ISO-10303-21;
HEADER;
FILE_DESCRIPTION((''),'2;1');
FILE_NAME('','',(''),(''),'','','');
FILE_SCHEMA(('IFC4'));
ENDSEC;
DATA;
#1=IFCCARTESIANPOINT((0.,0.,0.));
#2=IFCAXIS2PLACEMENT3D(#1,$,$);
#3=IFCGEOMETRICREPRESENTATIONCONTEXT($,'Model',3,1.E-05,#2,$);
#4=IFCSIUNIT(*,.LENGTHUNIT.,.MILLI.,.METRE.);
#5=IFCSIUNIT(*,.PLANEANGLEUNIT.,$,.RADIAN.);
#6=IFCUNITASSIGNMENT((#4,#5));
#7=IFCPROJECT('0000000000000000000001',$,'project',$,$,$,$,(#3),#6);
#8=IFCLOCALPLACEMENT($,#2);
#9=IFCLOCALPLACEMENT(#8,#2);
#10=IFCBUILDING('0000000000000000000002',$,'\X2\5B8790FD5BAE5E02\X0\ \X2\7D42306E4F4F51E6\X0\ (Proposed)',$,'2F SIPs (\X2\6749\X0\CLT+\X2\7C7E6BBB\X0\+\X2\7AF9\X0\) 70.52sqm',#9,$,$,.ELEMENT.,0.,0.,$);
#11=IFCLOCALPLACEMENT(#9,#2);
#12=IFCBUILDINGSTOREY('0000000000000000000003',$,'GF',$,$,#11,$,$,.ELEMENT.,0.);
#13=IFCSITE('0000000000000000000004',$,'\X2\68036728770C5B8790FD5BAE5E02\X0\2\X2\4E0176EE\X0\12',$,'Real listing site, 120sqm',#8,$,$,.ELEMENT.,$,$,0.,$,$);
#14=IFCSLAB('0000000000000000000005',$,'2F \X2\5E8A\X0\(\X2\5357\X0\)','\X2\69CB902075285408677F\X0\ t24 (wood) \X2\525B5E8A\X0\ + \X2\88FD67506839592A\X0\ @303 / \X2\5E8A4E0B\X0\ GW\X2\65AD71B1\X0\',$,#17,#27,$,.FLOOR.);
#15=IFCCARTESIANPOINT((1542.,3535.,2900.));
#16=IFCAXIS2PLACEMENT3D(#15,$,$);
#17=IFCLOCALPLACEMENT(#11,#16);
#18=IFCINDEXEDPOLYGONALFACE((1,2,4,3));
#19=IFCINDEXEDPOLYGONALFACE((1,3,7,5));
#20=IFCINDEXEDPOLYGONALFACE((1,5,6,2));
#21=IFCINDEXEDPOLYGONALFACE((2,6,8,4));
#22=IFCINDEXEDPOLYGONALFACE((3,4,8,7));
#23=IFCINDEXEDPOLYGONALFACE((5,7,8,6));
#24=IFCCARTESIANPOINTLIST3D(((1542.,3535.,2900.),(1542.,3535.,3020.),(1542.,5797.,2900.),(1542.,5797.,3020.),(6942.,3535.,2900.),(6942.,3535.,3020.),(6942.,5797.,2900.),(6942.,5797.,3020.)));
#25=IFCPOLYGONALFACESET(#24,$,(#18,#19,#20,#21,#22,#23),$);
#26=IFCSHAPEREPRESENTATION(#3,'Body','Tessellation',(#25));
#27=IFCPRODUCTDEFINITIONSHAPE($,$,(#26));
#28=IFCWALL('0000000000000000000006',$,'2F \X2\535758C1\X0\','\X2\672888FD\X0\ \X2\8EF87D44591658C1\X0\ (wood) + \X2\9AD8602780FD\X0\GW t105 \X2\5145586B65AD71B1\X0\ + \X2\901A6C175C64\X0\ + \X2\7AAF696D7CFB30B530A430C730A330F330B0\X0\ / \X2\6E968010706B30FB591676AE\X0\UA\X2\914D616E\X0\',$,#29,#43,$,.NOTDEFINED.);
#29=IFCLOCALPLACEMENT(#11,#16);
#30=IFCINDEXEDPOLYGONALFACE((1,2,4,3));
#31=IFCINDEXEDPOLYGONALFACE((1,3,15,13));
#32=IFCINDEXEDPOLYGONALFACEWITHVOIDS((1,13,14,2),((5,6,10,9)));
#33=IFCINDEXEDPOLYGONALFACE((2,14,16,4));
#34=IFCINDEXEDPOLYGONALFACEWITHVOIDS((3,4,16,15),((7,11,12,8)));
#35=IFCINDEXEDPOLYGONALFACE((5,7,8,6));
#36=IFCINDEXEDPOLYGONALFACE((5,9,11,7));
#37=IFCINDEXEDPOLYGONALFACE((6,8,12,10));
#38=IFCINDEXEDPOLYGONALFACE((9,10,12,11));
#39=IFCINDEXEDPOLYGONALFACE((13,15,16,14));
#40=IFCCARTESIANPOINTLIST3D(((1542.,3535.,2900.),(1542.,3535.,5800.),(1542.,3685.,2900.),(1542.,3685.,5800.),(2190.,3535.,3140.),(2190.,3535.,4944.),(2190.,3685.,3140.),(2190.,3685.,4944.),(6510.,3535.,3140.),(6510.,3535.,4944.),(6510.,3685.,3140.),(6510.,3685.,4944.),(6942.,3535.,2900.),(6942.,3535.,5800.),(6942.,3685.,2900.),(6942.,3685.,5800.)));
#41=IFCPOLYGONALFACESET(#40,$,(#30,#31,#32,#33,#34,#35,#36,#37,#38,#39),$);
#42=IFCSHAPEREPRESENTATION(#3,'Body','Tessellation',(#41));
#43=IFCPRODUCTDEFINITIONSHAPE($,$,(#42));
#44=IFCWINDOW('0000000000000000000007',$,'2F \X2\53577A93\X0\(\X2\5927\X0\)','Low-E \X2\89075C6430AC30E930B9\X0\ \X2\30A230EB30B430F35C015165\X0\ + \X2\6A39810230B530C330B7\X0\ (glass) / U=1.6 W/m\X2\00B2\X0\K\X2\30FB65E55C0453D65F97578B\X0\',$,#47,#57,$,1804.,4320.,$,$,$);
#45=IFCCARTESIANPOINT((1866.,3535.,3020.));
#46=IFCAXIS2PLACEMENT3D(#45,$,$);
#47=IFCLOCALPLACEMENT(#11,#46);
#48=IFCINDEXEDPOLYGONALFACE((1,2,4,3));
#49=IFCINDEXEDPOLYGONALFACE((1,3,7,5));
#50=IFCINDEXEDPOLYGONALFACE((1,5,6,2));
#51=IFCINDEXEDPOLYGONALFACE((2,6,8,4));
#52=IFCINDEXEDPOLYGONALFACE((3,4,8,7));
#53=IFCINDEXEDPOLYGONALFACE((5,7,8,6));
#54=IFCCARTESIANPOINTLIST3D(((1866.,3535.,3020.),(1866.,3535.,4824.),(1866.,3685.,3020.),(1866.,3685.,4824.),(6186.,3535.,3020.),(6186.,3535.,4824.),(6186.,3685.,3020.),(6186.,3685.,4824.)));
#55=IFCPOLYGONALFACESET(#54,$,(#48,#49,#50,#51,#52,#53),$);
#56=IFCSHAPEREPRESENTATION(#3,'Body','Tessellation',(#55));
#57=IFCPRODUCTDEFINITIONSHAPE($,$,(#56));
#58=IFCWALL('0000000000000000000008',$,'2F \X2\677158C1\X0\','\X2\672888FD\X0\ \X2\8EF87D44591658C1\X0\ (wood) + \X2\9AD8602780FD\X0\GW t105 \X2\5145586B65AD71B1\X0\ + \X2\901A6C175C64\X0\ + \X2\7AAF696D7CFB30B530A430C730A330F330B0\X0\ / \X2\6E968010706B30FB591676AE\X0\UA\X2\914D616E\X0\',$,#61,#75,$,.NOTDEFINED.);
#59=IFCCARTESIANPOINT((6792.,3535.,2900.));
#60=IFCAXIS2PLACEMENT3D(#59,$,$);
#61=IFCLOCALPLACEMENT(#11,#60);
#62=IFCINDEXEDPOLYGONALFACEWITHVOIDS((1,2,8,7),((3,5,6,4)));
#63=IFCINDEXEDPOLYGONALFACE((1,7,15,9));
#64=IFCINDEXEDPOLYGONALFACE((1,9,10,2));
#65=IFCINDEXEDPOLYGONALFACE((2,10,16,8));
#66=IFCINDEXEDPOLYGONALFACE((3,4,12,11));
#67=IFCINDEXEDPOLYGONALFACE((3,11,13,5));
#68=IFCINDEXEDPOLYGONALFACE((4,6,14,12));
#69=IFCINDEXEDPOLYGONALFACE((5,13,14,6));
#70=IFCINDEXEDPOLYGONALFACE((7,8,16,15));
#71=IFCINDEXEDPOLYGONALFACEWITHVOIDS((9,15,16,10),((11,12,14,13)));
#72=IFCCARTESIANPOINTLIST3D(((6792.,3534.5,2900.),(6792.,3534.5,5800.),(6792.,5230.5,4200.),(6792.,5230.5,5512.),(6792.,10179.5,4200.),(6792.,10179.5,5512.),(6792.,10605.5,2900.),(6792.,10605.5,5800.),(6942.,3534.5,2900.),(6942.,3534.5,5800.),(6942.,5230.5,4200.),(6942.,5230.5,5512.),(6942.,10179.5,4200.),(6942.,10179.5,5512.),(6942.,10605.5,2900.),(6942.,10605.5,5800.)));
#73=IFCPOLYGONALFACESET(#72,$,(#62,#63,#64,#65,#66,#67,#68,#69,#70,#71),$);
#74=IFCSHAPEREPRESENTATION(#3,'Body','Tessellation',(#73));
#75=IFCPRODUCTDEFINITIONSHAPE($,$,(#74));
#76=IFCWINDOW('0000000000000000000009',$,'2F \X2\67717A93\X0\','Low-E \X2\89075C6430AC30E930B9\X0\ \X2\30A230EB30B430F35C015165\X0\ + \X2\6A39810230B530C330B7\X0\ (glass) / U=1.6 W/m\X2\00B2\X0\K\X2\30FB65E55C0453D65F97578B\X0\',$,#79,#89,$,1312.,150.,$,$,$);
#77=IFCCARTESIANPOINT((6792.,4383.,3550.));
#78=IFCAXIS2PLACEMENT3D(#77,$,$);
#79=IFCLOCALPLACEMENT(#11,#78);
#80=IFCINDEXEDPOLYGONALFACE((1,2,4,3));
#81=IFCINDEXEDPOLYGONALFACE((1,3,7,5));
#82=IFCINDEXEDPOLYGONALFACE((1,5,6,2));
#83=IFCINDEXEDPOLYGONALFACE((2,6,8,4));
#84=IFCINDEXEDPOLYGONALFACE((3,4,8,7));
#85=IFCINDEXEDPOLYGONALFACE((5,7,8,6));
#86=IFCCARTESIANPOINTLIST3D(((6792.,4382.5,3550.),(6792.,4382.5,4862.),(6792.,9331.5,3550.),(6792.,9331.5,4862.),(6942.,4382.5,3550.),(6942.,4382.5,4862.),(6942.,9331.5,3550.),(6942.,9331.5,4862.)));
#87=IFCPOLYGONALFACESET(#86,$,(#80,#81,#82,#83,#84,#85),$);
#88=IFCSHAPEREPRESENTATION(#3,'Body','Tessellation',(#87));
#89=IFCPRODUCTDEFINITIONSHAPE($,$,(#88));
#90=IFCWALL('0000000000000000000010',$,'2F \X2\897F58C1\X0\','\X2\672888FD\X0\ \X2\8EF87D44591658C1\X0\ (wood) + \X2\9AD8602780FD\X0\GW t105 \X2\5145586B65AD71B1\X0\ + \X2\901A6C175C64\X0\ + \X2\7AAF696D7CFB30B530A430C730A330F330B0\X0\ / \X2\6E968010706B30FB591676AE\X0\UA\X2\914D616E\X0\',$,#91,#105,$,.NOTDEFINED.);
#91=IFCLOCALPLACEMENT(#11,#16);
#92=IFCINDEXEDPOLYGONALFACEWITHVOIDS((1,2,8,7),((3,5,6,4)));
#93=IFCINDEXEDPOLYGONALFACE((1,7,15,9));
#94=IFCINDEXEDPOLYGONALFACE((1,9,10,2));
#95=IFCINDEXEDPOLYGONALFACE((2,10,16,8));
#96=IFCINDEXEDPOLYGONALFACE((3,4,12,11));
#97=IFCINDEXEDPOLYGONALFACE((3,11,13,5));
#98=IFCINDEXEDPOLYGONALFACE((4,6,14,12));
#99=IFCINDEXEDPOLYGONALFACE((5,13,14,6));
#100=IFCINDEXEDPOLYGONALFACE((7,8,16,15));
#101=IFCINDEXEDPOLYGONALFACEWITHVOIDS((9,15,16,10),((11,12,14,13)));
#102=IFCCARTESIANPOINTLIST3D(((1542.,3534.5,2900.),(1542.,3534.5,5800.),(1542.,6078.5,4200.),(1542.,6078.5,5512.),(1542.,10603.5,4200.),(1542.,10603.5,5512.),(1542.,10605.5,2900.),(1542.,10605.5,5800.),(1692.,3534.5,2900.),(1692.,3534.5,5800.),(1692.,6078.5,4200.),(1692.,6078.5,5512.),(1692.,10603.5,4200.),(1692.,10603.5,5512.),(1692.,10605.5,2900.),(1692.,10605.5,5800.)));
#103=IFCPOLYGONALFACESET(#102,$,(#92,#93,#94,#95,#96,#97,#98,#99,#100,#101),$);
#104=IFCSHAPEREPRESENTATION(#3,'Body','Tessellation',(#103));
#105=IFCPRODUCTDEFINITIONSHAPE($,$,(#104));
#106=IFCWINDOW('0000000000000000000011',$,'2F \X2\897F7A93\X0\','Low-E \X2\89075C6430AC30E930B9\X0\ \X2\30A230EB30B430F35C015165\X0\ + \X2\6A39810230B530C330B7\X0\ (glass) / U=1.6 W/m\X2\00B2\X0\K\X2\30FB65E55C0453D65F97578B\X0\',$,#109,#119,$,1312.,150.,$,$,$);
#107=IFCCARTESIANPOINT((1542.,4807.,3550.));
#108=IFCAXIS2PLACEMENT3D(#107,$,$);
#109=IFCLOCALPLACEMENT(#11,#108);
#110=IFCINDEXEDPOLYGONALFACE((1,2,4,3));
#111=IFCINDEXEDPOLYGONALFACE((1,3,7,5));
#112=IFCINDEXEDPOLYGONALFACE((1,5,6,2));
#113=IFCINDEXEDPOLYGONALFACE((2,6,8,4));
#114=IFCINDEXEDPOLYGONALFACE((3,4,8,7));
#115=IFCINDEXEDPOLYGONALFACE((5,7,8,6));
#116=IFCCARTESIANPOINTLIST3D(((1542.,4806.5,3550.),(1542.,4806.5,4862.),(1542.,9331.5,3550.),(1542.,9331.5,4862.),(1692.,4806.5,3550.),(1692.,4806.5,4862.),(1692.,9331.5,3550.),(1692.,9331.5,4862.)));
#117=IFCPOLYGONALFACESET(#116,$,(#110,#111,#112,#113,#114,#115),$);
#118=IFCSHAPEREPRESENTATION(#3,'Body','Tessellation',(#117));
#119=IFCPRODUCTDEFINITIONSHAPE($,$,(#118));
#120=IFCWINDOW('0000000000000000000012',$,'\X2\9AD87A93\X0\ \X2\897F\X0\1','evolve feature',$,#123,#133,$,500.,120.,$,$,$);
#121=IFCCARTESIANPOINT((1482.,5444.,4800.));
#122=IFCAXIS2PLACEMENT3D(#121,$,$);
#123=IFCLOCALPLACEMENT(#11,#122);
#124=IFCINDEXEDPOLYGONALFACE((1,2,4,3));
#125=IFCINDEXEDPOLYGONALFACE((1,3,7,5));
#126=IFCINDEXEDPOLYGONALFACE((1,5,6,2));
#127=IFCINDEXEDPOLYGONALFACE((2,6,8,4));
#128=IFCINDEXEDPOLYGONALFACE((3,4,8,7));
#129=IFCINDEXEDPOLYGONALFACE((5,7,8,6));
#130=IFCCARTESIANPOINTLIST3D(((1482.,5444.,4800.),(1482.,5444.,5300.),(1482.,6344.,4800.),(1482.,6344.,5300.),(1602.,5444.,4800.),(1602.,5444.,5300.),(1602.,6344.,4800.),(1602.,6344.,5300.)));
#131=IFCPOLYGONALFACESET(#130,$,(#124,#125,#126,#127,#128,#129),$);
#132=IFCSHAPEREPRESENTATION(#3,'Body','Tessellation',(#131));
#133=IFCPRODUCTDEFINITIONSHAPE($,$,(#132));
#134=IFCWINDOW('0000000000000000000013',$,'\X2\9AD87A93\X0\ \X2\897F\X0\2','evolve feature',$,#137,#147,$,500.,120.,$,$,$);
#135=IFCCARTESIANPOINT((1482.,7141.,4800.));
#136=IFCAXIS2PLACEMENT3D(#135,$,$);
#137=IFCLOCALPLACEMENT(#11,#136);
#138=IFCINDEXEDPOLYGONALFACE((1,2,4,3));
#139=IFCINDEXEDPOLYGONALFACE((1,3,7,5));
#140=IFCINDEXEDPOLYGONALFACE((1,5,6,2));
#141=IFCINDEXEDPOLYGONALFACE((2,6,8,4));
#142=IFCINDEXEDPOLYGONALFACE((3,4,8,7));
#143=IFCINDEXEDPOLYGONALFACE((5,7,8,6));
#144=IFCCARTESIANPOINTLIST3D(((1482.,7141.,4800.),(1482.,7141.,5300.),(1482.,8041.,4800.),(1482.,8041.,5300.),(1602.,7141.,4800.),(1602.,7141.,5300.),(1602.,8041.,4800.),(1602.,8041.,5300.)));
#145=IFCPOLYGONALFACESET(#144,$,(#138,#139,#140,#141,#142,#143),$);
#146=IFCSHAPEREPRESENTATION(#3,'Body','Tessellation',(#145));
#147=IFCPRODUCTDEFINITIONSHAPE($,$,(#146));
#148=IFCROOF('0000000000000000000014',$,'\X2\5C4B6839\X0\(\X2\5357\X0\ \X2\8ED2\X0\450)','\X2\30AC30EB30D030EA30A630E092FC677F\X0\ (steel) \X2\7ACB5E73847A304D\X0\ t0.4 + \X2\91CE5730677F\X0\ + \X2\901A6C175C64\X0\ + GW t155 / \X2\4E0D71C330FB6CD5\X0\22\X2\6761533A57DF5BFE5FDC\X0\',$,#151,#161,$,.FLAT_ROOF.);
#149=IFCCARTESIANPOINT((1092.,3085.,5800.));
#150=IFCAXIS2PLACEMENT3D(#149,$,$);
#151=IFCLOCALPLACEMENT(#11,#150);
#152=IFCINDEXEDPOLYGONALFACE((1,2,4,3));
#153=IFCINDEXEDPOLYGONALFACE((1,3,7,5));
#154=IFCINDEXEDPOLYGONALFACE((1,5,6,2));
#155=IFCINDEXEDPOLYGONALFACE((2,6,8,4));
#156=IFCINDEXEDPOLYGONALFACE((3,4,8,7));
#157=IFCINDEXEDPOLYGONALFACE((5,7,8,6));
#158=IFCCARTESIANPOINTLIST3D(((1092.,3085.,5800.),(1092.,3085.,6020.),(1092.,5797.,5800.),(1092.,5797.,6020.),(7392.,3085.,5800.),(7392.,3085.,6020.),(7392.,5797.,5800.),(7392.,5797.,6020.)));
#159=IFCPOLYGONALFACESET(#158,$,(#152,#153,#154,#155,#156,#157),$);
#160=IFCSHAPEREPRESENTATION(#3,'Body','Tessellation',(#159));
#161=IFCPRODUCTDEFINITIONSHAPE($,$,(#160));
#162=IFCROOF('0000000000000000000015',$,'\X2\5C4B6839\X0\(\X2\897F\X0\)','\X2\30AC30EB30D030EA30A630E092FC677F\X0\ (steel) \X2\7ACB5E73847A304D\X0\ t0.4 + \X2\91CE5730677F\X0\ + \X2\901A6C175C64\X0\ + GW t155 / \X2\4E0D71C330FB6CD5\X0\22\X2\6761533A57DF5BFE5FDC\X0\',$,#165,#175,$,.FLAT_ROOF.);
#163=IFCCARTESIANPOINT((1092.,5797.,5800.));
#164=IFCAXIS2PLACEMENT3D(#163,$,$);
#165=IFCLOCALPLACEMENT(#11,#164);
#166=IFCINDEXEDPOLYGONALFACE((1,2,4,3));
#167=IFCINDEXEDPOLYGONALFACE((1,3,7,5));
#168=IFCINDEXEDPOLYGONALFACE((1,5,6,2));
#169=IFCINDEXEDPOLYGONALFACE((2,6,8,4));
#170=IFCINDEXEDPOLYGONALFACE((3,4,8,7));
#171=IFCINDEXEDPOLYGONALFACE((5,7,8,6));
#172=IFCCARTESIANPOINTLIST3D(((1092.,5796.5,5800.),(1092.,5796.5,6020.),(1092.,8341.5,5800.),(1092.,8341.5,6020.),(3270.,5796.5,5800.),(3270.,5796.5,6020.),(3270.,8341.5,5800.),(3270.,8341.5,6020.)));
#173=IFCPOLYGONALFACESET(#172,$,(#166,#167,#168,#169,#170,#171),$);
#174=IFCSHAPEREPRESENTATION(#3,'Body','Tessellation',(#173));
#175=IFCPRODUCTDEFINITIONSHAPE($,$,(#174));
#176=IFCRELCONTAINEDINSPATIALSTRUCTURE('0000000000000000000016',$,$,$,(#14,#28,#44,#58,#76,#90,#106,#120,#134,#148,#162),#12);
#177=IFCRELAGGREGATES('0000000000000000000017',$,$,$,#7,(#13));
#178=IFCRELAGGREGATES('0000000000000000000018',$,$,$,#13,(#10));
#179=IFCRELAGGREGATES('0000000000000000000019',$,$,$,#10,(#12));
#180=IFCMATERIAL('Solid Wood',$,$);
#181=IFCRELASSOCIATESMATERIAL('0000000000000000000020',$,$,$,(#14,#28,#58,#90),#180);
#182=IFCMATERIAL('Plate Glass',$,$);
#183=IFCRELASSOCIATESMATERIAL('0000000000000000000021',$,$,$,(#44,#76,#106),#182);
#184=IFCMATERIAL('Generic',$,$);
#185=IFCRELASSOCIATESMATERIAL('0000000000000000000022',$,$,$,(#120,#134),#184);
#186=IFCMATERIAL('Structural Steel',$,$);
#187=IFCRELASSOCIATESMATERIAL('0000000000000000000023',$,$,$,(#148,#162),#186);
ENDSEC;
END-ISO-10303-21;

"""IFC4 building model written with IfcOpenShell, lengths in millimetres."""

from ifc_helpers import new_model, si_unit, frame, frame_2d, origin, place, context, project, spatial, rectangle, extrude, material, element, fill, save


model = new_model("IFC4")

# Units and contexts
model_context = context("Model", 3, precision=1e-05, world=origin())
ifc_project = project(units=[si_unit("LENGTHUNIT", "METRE", prefix="MILLI"), si_unit("PLANEANGLEUNIT", "RADIAN")], contexts=[model_context])

# Site, building, storey
site_placement = place(None, origin())
site = spatial("IfcSite", under=ifc_project, at=site_placement, Name="栃木県宇都宮市2丁目12", ObjectType="Real listing site, 120sqm", CompositionType="ELEMENT", RefElevation=0.0)
building_placement = place(site_placement, origin())
building = spatial("IfcBuilding", under=site, at=building_placement, Name="宇都宮市 終の住処 (Proposed)", ObjectType="2F SIPs (杉CLT+籾殻+竹) 70.52sqm", CompositionType="ELEMENT", ElevationOfRefHeight=0.0, ElevationOfTerrain=0.0)
storey_placement = place(building_placement, origin())
storey = spatial("IfcBuildingStorey", under=building, at=storey_placement, Name="GF", CompositionType="ELEMENT", Elevation=0.0)

# Slab
ifc_material_1 = material(Name="Solid Wood")
slab_placement = place(storey_placement, frame((1542.0, 3535.0, 2900.0)))
element("IfcSlab", 1, at=slab_placement, inside=storey, material=ifc_material_1, Name="2F 床(南)", Description="構造用合板 t24 (wood) 剛床 + 製材根太 @303 / 床下 GW断熱", PredefinedType="FLOOR", context=model_context, shape_type="SweptSolid", body=[
    extrude(rectangle(XDim=5400.0, YDim=2262.0, at=frame_2d((2700.0, 1131.0))), frame((1542.0, 3535.0, 2900.0)), (0.0, 0.0, 1.0), 120.0),
])

# Walls, openings, windows
wall_1_placement = place(storey_placement, frame((1542.0, 3535.0, 2900.0)))
wall_1 = element("IfcWall", 2, at=wall_1_placement, inside=storey, material=ifc_material_1, Name="2F 南壁", Description="木製 軸組外壁 (wood) + 高性能GW t105 充填断熱 + 通気層 + 窯業系サイディング / 準耐火・外皮UA配慮", PredefinedType="NOTDEFINED", context=model_context, shape_type="SweptSolid", body=[
    extrude(rectangle(XDim=5400.0, YDim=150.0, at=frame_2d((2700.0, 75.0))), frame((1542.0, 3535.0, 2900.0)), (0.0, 0.0, 1.0), 2900.0),
])
opening_1_placement = place(storey_placement, frame((1866.0, 3535.0, 3020.0)))
opening_1 = element("IfcOpeningElement", 3, at=opening_1_placement, cuts=wall_1, PredefinedType="NOTDEFINED", context=model_context, shape_type="SweptSolid", body=[
    extrude(rectangle(XDim=4320.0, YDim=150.0, at=frame_2d((2160.0, 75.0))), frame((1866.0, 3535.0, 3020.0)), (0.0, 0.0, 1.0), 1804.0),
])
ifc_material_2 = material(Name="Plate Glass")
window_1_placement = place(storey_placement, frame((1866.0, 3535.0, 3020.0)))
window_1 = element("IfcWindow", 4, at=window_1_placement, inside=storey, material=ifc_material_2, Name="2F 南窓(大)", Description="Low-E 複層ガラス アルゴン封入 + 樹脂サッシ (glass) / U=1.6 W/m²K・日射取得型", OverallHeight=1804.0, OverallWidth=4320.0, context=model_context, shape_type="SweptSolid", body=[
    extrude(rectangle(XDim=4320.0, YDim=150.0, at=frame_2d((2160.0, 75.0))), frame((1866.0, 3535.0, 3020.0)), (0.0, 0.0, 1.0), 1804.0),
])
fill(opening_1, window_1)
wall_2_placement = place(storey_placement, frame((6792.0, 3535.0, 2900.0)))
wall_2 = element("IfcWall", 5, at=wall_2_placement, inside=storey, material=ifc_material_1, Name="2F 東壁", Description="木製 軸組外壁 (wood) + 高性能GW t105 充填断熱 + 通気層 + 窯業系サイディング / 準耐火・外皮UA配慮", PredefinedType="NOTDEFINED", context=model_context, shape_type="SweptSolid", body=[
    extrude(rectangle(XDim=150.0, YDim=7071.0, at=frame_2d((75.0, 3535.0))), frame((6792.0, 3535.0, 2900.0)), (0.0, 0.0, 1.0), 2900.0),
])
opening_2_placement = place(storey_placement, frame((6792.0, 4383.0, 3550.0)))
opening_2 = element("IfcOpeningElement", 6, at=opening_2_placement, cuts=wall_2, PredefinedType="NOTDEFINED", context=model_context, shape_type="SweptSolid", body=[
    extrude(rectangle(XDim=150.0, YDim=4949.0, at=frame_2d((75.0, 2474.0))), frame((6792.0, 4383.0, 3550.0)), (0.0, 0.0, 1.0), 1312.0),
])
window_2_placement = place(storey_placement, frame((6792.0, 4383.0, 3550.0)))
window_2 = element("IfcWindow", 7, at=window_2_placement, inside=storey, material=ifc_material_2, Name="2F 東窓", Description="Low-E 複層ガラス アルゴン封入 + 樹脂サッシ (glass) / U=1.6 W/m²K・日射取得型", OverallHeight=1312.0, OverallWidth=150.0, context=model_context, shape_type="SweptSolid", body=[
    extrude(rectangle(XDim=150.0, YDim=4949.0, at=frame_2d((75.0, 2474.0))), frame((6792.0, 4383.0, 3550.0)), (0.0, 0.0, 1.0), 1312.0),
])
fill(opening_2, window_2)

# Wall, openings, windows
wall_3_placement = place(storey_placement, frame((1542.0, 3535.0, 2900.0)))
wall_3 = element("IfcWall", 8, at=wall_3_placement, inside=storey, material=ifc_material_1, Name="2F 西壁", Description="木製 軸組外壁 (wood) + 高性能GW t105 充填断熱 + 通気層 + 窯業系サイディング / 準耐火・外皮UA配慮", PredefinedType="NOTDEFINED", context=model_context, shape_type="SweptSolid", body=[
    extrude(rectangle(XDim=150.0, YDim=7071.0, at=frame_2d((75.0, 3535.0))), frame((1542.0, 3535.0, 2900.0)), (0.0, 0.0, 1.0), 2900.0),
])
opening_3_placement = place(storey_placement, frame((1542.0, 4807.0, 3550.0)))
opening_3 = element("IfcOpeningElement", 9, at=opening_3_placement, cuts=wall_3, PredefinedType="NOTDEFINED", context=model_context, shape_type="SweptSolid", body=[
    extrude(rectangle(XDim=150.0, YDim=4525.0, at=frame_2d((75.0, 2262.0))), frame((1542.0, 4807.0, 3550.0)), (0.0, 0.0, 1.0), 1312.0),
])
opening_4_placement = place(storey_placement, frame((1482.0, 5444.0, 4800.0)))
opening_4 = element("IfcOpeningElement", 10, at=opening_4_placement, cuts=wall_3, PredefinedType="NOTDEFINED", context=model_context, shape_type="SweptSolid", body=[
    extrude(rectangle(XDim=120.0, YDim=900.0, at=frame_2d((60.0, 450.0))), frame((1482.0, 5444.0, 4800.0)), (0.0, 0.0, 1.0), 500.0),
])
opening_5_placement = place(storey_placement, frame((1482.0, 7141.0, 4800.0)))
opening_5 = element("IfcOpeningElement", 11, at=opening_5_placement, cuts=wall_3, PredefinedType="NOTDEFINED", context=model_context, shape_type="SweptSolid", body=[
    extrude(rectangle(XDim=120.0, YDim=900.0, at=frame_2d((60.0, 450.0))), frame((1482.0, 7141.0, 4800.0)), (0.0, 0.0, 1.0), 500.0),
])
window_3_placement = place(storey_placement, frame((1542.0, 4807.0, 3550.0)))
window_3 = element("IfcWindow", 12, at=window_3_placement, inside=storey, material=ifc_material_2, Name="2F 西窓", Description="Low-E 複層ガラス アルゴン封入 + 樹脂サッシ (glass) / U=1.6 W/m²K・日射取得型", OverallHeight=1312.0, OverallWidth=150.0, context=model_context, shape_type="SweptSolid", body=[
    extrude(rectangle(XDim=150.0, YDim=4525.0, at=frame_2d((75.0, 2262.0))), frame((1542.0, 4807.0, 3550.0)), (0.0, 0.0, 1.0), 1312.0),
])
fill(opening_3, window_3)
ifc_material_3 = material(Name="Generic")
window_4_placement = place(storey_placement, frame((1482.0, 5444.0, 4800.0)))
window_4 = element("IfcWindow", 13, at=window_4_placement, inside=storey, material=ifc_material_3, Name="高窓 西1", Description="evolve feature", OverallHeight=500.0, OverallWidth=120.0, context=model_context, shape_type="SweptSolid", body=[
    extrude(rectangle(XDim=120.0, YDim=900.0, at=frame_2d((60.0, 450.0))), frame((1482.0, 5444.0, 4800.0)), (0.0, 0.0, 1.0), 500.0),
])
fill(opening_4, window_4)
window_5_placement = place(storey_placement, frame((1482.0, 7141.0, 4800.0)))
window_5 = element("IfcWindow", 14, at=window_5_placement, inside=storey, material=ifc_material_3, Name="高窓 西2", Description="evolve feature", OverallHeight=500.0, OverallWidth=120.0, context=model_context, shape_type="SweptSolid", body=[
    extrude(rectangle(XDim=120.0, YDim=900.0, at=frame_2d((60.0, 450.0))), frame((1482.0, 7141.0, 4800.0)), (0.0, 0.0, 1.0), 500.0),
])
fill(opening_5, window_5)

# Roofs
ifc_material_4 = material(Name="Structural Steel")
roof_1_placement = place(storey_placement, frame((1092.0, 3085.0, 5800.0)))
element("IfcRoof", 15, at=roof_1_placement, inside=storey, material=ifc_material_4, Name="屋根(南 軒450)", Description="ガルバリウム鋼板 (steel) 立平葺き t0.4 + 野地板 + 通気層 + GW t155 / 不燃・法22条区域対応", PredefinedType="FLAT_ROOF", context=model_context, shape_type="SweptSolid", body=[
    extrude(rectangle(XDim=6300.0, YDim=2712.0, at=frame_2d((3150.0, 1356.0))), frame((1092.0, 3085.0, 5800.0)), (0.0, 0.0, 1.0), 220.0),
])
roof_2_placement = place(storey_placement, frame((1092.0, 5797.0, 5800.0)))
element("IfcRoof", 16, at=roof_2_placement, inside=storey, material=ifc_material_4, Name="屋根(西)", Description="ガルバリウム鋼板 (steel) 立平葺き t0.4 + 野地板 + 通気層 + GW t155 / 不燃・法22条区域対応", PredefinedType="FLAT_ROOF", context=model_context, shape_type="SweptSolid", body=[
    extrude(rectangle(XDim=2178.0, YDim=2545.0, at=frame_2d((1089.0, 1272.0))), frame((1092.0, 5797.0, 5800.0)), (0.0, 0.0, 1.0), 220.0),
])

save(model, "model.ifc")
